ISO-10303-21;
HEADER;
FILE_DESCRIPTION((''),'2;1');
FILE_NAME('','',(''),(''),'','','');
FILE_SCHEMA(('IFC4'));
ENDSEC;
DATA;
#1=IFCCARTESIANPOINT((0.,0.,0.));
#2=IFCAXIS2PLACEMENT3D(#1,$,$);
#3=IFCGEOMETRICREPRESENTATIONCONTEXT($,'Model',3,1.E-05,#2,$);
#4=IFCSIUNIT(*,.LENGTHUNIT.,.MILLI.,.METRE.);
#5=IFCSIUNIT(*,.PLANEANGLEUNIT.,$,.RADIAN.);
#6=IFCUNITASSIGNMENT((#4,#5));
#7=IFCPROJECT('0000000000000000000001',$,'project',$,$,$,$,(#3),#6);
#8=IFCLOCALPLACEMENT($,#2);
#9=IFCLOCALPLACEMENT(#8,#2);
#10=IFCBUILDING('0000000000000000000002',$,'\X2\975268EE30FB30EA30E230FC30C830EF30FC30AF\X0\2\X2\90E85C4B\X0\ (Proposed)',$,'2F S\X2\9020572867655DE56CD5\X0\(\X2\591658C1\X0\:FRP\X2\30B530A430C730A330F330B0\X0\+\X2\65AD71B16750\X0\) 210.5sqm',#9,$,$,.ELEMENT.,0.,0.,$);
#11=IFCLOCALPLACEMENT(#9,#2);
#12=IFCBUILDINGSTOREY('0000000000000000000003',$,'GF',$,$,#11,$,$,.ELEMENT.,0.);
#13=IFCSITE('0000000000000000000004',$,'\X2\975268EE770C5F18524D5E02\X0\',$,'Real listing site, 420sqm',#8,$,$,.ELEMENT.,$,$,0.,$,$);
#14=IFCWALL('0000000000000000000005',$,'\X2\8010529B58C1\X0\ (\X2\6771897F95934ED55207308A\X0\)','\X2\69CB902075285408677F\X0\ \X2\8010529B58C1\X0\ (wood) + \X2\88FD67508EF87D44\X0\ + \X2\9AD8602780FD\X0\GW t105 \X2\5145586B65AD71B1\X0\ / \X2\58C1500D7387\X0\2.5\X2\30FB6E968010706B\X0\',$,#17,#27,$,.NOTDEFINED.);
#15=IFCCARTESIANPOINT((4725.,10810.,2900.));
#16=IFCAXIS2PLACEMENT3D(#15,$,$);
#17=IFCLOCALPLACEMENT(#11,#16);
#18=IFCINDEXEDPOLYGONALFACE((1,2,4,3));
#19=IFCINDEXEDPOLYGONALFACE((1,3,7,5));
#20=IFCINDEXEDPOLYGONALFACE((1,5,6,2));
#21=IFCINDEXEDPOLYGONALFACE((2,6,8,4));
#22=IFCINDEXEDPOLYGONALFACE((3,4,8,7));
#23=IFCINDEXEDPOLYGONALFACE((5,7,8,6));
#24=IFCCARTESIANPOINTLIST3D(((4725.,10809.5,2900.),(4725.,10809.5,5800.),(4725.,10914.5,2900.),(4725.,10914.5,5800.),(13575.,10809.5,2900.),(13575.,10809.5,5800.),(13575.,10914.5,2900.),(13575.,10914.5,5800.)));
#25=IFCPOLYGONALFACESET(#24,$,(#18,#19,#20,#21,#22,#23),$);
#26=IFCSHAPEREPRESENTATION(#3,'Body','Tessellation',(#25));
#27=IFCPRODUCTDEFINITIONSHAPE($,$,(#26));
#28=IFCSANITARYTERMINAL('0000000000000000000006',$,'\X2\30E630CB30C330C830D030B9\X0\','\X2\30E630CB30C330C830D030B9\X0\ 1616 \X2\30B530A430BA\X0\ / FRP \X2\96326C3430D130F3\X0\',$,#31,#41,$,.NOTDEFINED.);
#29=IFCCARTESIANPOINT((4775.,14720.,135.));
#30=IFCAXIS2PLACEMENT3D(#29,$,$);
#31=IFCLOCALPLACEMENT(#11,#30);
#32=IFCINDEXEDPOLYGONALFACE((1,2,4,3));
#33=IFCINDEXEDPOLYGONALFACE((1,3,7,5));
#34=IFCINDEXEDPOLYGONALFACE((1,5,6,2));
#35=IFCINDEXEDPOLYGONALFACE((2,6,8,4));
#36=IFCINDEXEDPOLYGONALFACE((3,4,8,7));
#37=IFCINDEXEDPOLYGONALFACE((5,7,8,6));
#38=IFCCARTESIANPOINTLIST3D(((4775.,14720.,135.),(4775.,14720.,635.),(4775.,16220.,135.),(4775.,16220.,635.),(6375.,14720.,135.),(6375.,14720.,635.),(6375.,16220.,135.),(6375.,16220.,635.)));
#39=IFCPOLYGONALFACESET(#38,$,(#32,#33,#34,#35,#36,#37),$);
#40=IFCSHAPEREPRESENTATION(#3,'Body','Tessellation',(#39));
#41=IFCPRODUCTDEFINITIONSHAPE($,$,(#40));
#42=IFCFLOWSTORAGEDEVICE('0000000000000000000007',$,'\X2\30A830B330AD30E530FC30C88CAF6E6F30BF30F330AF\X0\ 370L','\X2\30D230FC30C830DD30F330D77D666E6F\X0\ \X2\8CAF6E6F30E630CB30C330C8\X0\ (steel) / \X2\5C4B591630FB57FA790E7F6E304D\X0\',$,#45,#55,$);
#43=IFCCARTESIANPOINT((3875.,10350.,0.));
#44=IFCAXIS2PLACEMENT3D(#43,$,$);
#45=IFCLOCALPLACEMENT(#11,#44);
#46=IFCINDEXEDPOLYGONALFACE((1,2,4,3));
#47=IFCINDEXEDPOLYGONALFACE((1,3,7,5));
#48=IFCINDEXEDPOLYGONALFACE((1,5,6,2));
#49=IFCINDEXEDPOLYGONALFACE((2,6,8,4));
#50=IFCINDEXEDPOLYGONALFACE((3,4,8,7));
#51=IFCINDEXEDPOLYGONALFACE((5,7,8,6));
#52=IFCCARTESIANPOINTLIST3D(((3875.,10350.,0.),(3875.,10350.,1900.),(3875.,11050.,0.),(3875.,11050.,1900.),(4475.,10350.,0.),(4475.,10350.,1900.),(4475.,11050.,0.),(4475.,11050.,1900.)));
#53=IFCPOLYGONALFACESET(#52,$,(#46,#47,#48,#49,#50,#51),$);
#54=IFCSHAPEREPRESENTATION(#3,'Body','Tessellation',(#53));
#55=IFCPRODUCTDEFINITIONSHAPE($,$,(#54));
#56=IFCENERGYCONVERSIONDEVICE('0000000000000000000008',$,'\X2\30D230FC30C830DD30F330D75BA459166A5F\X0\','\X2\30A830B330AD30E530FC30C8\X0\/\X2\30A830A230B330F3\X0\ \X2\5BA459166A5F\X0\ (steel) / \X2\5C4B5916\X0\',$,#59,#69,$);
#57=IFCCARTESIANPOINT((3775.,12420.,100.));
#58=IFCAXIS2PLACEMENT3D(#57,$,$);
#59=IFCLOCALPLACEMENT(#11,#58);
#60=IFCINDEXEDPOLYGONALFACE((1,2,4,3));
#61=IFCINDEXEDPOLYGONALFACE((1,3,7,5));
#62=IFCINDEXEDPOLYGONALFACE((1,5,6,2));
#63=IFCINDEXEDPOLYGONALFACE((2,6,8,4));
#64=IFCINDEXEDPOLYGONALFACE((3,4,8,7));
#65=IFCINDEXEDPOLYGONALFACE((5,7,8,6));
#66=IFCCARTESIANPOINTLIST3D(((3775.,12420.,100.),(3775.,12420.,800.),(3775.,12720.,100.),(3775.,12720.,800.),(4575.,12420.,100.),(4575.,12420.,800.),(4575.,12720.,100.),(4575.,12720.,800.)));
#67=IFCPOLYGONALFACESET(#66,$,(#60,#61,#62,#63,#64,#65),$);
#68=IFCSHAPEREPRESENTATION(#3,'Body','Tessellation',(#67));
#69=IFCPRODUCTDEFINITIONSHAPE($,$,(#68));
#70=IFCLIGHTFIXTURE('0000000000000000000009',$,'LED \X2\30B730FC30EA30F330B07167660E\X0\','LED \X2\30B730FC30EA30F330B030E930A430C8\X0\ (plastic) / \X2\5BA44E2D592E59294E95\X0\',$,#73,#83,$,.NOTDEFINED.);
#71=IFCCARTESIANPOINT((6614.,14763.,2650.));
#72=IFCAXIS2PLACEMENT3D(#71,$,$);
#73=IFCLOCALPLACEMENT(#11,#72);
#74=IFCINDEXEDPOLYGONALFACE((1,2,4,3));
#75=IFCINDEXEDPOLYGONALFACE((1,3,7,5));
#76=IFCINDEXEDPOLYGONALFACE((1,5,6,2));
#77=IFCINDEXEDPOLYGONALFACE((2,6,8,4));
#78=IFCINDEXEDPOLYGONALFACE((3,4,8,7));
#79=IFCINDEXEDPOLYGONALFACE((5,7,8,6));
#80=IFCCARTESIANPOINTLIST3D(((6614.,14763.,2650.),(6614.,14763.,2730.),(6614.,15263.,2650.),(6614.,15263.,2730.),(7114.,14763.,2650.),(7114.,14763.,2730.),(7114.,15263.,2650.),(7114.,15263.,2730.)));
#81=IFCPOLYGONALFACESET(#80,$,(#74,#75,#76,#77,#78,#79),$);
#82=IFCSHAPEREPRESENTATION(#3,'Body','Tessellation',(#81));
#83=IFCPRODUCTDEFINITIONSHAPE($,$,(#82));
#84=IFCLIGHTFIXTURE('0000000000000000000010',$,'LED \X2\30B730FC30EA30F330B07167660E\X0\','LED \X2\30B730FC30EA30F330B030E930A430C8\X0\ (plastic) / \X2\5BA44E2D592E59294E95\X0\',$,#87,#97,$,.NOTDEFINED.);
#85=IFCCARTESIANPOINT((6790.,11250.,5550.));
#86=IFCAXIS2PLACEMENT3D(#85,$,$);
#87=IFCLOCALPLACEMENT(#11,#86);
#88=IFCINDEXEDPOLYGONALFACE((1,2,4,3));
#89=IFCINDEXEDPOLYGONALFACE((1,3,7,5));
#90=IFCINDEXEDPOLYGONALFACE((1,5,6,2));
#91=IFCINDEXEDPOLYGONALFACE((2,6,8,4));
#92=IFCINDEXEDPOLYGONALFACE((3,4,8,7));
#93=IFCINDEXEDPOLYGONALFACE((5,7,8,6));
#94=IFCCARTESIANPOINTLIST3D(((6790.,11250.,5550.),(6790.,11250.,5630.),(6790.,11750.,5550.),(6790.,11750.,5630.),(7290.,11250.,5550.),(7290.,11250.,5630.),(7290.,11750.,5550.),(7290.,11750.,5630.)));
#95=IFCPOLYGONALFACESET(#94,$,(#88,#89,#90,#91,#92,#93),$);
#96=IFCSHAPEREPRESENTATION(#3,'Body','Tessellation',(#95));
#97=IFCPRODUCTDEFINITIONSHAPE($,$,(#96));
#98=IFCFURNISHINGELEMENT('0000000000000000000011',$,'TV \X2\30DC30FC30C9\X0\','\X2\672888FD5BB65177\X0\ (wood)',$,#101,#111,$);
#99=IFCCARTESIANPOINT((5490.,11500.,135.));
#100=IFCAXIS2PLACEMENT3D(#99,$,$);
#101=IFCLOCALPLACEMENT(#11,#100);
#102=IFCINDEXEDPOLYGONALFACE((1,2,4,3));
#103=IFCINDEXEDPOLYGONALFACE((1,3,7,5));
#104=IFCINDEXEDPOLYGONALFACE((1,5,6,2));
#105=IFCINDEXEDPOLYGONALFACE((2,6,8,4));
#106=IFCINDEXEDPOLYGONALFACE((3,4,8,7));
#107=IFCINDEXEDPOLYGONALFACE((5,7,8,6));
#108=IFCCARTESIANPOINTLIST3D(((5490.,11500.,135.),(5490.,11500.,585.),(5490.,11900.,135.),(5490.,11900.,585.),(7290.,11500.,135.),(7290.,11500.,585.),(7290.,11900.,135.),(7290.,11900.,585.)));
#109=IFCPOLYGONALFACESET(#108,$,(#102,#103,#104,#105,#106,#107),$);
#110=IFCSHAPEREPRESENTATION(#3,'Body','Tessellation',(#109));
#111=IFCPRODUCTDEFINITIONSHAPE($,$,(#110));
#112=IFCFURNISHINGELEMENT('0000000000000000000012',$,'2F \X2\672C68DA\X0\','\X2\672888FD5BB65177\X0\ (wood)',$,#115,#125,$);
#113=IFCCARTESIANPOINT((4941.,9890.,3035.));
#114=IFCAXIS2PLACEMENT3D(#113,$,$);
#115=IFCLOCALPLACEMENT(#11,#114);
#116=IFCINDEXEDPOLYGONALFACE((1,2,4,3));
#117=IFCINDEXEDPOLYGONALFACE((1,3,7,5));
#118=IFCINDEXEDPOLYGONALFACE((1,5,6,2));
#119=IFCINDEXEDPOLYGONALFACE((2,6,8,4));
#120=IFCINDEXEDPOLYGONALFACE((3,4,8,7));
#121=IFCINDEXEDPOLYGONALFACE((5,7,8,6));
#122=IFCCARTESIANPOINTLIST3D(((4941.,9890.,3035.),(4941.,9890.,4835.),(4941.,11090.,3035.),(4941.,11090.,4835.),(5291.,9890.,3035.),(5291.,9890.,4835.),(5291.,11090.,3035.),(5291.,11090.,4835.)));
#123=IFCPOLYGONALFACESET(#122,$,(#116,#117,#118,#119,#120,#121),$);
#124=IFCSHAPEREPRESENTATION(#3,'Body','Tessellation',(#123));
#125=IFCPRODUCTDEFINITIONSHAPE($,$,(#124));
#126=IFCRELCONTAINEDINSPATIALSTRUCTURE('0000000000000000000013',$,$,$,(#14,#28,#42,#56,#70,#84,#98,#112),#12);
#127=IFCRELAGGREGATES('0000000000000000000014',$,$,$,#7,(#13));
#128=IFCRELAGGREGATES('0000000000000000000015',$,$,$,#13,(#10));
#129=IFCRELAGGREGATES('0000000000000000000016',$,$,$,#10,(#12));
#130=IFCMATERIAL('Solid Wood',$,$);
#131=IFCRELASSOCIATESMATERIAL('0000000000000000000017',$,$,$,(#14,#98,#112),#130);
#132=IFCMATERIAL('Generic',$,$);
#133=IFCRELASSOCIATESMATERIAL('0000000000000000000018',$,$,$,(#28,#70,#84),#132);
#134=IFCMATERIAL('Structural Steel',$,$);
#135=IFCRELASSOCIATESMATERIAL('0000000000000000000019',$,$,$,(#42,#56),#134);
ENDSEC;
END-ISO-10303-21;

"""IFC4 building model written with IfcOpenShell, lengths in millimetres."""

from ifc_helpers import new_model, si_unit, frame, frame_2d, origin, place, context, project, spatial, rectangle, extrude, material, element, save


model = new_model("IFC4")

# Units and contexts
model_context = context("Model", 3, precision=1e-05, world=origin())
ifc_project = project(units=[si_unit("LENGTHUNIT", "METRE", prefix="MILLI"), si_unit("PLANEANGLEUNIT", "RADIAN")], contexts=[model_context])

# Site, building, storey
site_placement = place(None, origin())
site = spatial("IfcSite", under=ifc_project, at=site_placement, Name="青森県弘前市", ObjectType="Real listing site, 420sqm", CompositionType="ELEMENT", RefElevation=0.0)
building_placement = place(site_placement, origin())
building = spatial("IfcBuilding", under=site, at=building_placement, Name="青森・リモートワーク2部屋 (Proposed)", ObjectType="2F S造在来工法(外壁:FRPサイディング+断熱材) 210.5sqm", CompositionType="ELEMENT", ElevationOfRefHeight=0.0, ElevationOfTerrain=0.0)
storey_placement = place(building_placement, origin())
storey = spatial("IfcBuildingStorey", under=building, at=storey_placement, Name="GF", CompositionType="ELEMENT", Elevation=0.0)

# Shared definitions
ifc_material_1 = material(Name="Solid Wood")

# Wall
wall_1_placement = place(storey_placement, frame((4725.0, 10810.0, 2900.0)))
element("IfcWall", 1, at=wall_1_placement, inside=storey, material=ifc_material_1, Name="耐力壁 (東西間仕切り)", Description="構造用合板 耐力壁 (wood) + 製材軸組 + 高性能GW t105 充填断熱 / 壁倍率2.5・準耐火", PredefinedType="NOTDEFINED", context=model_context, shape_type="SweptSolid", body=[
    extrude(rectangle(XDim=8850.0, YDim=105.0, at=frame_2d((4425.0, 52.0))), frame((4725.0, 10810.0, 2900.0)), (0.0, 0.0, 1.0), 2900.0),
])

# Sanitary terminal
ifc_material_2 = material(Name="Generic")
sanitary_terminal_placement = place(storey_placement, frame((4775.0, 14720.0, 135.0)))
element("IfcSanitaryTerminal", 2, at=sanitary_terminal_placement, inside=storey, material=ifc_material_2, Name="ユニットバス", Description="ユニットバス 1616 サイズ / FRP 防水パン", PredefinedType="NOTDEFINED", context=model_context, shape_type="SweptSolid", body=[
    extrude(rectangle(XDim=1600.0, YDim=1500.0, at=frame_2d((800.0, 750.0))), frame((4775.0, 14720.0, 135.0)), (0.0, 0.0, 1.0), 500.0),
])

# Flow storage device
ifc_material_3 = material(Name="Structural Steel")
flow_storage_device_placement = place(storey_placement, frame((3875.0, 10350.0, 0.0)))
element("IfcFlowStorageDevice", 3, at=flow_storage_device_placement, inside=storey, material=ifc_material_3, Name="エコキュート貯湯タンク 370L", Description="ヒートポンプ給湯 貯湯ユニット (steel) / 屋外・基礎置き", context=model_context, shape_type="SweptSolid", body=[
    extrude(rectangle(XDim=600.0, YDim=700.0, at=frame_2d((300.0, 350.0))), frame((3875.0, 10350.0, 0.0)), (0.0, 0.0, 1.0), 1900.0),
])

# Energy conversion device
energy_conversion_device_placement = place(storey_placement, frame((3775.0, 12420.0, 100.0)))
element("IfcEnergyConversionDevice", 4, at=energy_conversion_device_placement, inside=storey, material=ifc_material_3, Name="ヒートポンプ室外機", Description="エコキュート/エアコン 室外機 (steel) / 屋外", context=model_context, shape_type="SweptSolid", body=[
    extrude(rectangle(XDim=800.0, YDim=300.0, at=frame_2d((400.0, 150.0))), frame((3775.0, 12420.0, 100.0)), (0.0, 0.0, 1.0), 700.0),
])

# Light fixtures
light_fixture_1_placement = place(storey_placement, frame((6614.0, 14763.0, 2650.0)))
element("IfcLightFixture", 5, at=light_fixture_1_placement, inside=storey, material=ifc_material_2, Name="LED シーリング照明", Description="LED シーリングライト (plastic) / 室中央天井", PredefinedType="NOTDEFINED", context=model_context, shape_type="SweptSolid", body=[
    extrude(rectangle(XDim=500.0, YDim=500.0, at=frame_2d((250.0, 250.0))), frame((6614.0, 14763.0, 2650.0)), (0.0, 0.0, 1.0), 80.0),
])
light_fixture_2_placement = place(storey_placement, frame((6790.0, 11250.0, 5550.0)))
element("IfcLightFixture", 6, at=light_fixture_2_placement, inside=storey, material=ifc_material_2, Name="LED シーリング照明", Description="LED シーリングライト (plastic) / 室中央天井", PredefinedType="NOTDEFINED", context=model_context, shape_type="SweptSolid", body=[
    extrude(rectangle(XDim=500.0, YDim=500.0, at=frame_2d((250.0, 250.0))), frame((6790.0, 11250.0, 5550.0)), (0.0, 0.0, 1.0), 80.0),
])

# Furnishing elements
furnishing_1_placement = place(storey_placement, frame((5490.0, 11500.0, 135.0)))
element("IfcFurnishingElement", 7, at=furnishing_1_placement, inside=storey, material=ifc_material_1, Name="TV ボード", Description="木製家具 (wood)", context=model_context, shape_type="SweptSolid", body=[
    extrude(rectangle(XDim=1800.0, YDim=400.0, at=frame_2d((900.0, 200.0))), frame((5490.0, 11500.0, 135.0)), (0.0, 0.0, 1.0), 450.0),
])
furnishing_2_placement = place(storey_placement, frame((4941.0, 9890.0, 3035.0)))
element("IfcFurnishingElement", 8, at=furnishing_2_placement, inside=storey, material=ifc_material_1, Name="2F 本棚", Description="木製家具 (wood)", context=model_context, shape_type="SweptSolid", body=[
    extrude(rectangle(XDim=350.0, YDim=1200.0, at=frame_2d((175.0, 600.0))), frame((4941.0, 9890.0, 3035.0)), (0.0, 0.0, 1.0), 1800.0),
])

save(model, "model.ifc")
